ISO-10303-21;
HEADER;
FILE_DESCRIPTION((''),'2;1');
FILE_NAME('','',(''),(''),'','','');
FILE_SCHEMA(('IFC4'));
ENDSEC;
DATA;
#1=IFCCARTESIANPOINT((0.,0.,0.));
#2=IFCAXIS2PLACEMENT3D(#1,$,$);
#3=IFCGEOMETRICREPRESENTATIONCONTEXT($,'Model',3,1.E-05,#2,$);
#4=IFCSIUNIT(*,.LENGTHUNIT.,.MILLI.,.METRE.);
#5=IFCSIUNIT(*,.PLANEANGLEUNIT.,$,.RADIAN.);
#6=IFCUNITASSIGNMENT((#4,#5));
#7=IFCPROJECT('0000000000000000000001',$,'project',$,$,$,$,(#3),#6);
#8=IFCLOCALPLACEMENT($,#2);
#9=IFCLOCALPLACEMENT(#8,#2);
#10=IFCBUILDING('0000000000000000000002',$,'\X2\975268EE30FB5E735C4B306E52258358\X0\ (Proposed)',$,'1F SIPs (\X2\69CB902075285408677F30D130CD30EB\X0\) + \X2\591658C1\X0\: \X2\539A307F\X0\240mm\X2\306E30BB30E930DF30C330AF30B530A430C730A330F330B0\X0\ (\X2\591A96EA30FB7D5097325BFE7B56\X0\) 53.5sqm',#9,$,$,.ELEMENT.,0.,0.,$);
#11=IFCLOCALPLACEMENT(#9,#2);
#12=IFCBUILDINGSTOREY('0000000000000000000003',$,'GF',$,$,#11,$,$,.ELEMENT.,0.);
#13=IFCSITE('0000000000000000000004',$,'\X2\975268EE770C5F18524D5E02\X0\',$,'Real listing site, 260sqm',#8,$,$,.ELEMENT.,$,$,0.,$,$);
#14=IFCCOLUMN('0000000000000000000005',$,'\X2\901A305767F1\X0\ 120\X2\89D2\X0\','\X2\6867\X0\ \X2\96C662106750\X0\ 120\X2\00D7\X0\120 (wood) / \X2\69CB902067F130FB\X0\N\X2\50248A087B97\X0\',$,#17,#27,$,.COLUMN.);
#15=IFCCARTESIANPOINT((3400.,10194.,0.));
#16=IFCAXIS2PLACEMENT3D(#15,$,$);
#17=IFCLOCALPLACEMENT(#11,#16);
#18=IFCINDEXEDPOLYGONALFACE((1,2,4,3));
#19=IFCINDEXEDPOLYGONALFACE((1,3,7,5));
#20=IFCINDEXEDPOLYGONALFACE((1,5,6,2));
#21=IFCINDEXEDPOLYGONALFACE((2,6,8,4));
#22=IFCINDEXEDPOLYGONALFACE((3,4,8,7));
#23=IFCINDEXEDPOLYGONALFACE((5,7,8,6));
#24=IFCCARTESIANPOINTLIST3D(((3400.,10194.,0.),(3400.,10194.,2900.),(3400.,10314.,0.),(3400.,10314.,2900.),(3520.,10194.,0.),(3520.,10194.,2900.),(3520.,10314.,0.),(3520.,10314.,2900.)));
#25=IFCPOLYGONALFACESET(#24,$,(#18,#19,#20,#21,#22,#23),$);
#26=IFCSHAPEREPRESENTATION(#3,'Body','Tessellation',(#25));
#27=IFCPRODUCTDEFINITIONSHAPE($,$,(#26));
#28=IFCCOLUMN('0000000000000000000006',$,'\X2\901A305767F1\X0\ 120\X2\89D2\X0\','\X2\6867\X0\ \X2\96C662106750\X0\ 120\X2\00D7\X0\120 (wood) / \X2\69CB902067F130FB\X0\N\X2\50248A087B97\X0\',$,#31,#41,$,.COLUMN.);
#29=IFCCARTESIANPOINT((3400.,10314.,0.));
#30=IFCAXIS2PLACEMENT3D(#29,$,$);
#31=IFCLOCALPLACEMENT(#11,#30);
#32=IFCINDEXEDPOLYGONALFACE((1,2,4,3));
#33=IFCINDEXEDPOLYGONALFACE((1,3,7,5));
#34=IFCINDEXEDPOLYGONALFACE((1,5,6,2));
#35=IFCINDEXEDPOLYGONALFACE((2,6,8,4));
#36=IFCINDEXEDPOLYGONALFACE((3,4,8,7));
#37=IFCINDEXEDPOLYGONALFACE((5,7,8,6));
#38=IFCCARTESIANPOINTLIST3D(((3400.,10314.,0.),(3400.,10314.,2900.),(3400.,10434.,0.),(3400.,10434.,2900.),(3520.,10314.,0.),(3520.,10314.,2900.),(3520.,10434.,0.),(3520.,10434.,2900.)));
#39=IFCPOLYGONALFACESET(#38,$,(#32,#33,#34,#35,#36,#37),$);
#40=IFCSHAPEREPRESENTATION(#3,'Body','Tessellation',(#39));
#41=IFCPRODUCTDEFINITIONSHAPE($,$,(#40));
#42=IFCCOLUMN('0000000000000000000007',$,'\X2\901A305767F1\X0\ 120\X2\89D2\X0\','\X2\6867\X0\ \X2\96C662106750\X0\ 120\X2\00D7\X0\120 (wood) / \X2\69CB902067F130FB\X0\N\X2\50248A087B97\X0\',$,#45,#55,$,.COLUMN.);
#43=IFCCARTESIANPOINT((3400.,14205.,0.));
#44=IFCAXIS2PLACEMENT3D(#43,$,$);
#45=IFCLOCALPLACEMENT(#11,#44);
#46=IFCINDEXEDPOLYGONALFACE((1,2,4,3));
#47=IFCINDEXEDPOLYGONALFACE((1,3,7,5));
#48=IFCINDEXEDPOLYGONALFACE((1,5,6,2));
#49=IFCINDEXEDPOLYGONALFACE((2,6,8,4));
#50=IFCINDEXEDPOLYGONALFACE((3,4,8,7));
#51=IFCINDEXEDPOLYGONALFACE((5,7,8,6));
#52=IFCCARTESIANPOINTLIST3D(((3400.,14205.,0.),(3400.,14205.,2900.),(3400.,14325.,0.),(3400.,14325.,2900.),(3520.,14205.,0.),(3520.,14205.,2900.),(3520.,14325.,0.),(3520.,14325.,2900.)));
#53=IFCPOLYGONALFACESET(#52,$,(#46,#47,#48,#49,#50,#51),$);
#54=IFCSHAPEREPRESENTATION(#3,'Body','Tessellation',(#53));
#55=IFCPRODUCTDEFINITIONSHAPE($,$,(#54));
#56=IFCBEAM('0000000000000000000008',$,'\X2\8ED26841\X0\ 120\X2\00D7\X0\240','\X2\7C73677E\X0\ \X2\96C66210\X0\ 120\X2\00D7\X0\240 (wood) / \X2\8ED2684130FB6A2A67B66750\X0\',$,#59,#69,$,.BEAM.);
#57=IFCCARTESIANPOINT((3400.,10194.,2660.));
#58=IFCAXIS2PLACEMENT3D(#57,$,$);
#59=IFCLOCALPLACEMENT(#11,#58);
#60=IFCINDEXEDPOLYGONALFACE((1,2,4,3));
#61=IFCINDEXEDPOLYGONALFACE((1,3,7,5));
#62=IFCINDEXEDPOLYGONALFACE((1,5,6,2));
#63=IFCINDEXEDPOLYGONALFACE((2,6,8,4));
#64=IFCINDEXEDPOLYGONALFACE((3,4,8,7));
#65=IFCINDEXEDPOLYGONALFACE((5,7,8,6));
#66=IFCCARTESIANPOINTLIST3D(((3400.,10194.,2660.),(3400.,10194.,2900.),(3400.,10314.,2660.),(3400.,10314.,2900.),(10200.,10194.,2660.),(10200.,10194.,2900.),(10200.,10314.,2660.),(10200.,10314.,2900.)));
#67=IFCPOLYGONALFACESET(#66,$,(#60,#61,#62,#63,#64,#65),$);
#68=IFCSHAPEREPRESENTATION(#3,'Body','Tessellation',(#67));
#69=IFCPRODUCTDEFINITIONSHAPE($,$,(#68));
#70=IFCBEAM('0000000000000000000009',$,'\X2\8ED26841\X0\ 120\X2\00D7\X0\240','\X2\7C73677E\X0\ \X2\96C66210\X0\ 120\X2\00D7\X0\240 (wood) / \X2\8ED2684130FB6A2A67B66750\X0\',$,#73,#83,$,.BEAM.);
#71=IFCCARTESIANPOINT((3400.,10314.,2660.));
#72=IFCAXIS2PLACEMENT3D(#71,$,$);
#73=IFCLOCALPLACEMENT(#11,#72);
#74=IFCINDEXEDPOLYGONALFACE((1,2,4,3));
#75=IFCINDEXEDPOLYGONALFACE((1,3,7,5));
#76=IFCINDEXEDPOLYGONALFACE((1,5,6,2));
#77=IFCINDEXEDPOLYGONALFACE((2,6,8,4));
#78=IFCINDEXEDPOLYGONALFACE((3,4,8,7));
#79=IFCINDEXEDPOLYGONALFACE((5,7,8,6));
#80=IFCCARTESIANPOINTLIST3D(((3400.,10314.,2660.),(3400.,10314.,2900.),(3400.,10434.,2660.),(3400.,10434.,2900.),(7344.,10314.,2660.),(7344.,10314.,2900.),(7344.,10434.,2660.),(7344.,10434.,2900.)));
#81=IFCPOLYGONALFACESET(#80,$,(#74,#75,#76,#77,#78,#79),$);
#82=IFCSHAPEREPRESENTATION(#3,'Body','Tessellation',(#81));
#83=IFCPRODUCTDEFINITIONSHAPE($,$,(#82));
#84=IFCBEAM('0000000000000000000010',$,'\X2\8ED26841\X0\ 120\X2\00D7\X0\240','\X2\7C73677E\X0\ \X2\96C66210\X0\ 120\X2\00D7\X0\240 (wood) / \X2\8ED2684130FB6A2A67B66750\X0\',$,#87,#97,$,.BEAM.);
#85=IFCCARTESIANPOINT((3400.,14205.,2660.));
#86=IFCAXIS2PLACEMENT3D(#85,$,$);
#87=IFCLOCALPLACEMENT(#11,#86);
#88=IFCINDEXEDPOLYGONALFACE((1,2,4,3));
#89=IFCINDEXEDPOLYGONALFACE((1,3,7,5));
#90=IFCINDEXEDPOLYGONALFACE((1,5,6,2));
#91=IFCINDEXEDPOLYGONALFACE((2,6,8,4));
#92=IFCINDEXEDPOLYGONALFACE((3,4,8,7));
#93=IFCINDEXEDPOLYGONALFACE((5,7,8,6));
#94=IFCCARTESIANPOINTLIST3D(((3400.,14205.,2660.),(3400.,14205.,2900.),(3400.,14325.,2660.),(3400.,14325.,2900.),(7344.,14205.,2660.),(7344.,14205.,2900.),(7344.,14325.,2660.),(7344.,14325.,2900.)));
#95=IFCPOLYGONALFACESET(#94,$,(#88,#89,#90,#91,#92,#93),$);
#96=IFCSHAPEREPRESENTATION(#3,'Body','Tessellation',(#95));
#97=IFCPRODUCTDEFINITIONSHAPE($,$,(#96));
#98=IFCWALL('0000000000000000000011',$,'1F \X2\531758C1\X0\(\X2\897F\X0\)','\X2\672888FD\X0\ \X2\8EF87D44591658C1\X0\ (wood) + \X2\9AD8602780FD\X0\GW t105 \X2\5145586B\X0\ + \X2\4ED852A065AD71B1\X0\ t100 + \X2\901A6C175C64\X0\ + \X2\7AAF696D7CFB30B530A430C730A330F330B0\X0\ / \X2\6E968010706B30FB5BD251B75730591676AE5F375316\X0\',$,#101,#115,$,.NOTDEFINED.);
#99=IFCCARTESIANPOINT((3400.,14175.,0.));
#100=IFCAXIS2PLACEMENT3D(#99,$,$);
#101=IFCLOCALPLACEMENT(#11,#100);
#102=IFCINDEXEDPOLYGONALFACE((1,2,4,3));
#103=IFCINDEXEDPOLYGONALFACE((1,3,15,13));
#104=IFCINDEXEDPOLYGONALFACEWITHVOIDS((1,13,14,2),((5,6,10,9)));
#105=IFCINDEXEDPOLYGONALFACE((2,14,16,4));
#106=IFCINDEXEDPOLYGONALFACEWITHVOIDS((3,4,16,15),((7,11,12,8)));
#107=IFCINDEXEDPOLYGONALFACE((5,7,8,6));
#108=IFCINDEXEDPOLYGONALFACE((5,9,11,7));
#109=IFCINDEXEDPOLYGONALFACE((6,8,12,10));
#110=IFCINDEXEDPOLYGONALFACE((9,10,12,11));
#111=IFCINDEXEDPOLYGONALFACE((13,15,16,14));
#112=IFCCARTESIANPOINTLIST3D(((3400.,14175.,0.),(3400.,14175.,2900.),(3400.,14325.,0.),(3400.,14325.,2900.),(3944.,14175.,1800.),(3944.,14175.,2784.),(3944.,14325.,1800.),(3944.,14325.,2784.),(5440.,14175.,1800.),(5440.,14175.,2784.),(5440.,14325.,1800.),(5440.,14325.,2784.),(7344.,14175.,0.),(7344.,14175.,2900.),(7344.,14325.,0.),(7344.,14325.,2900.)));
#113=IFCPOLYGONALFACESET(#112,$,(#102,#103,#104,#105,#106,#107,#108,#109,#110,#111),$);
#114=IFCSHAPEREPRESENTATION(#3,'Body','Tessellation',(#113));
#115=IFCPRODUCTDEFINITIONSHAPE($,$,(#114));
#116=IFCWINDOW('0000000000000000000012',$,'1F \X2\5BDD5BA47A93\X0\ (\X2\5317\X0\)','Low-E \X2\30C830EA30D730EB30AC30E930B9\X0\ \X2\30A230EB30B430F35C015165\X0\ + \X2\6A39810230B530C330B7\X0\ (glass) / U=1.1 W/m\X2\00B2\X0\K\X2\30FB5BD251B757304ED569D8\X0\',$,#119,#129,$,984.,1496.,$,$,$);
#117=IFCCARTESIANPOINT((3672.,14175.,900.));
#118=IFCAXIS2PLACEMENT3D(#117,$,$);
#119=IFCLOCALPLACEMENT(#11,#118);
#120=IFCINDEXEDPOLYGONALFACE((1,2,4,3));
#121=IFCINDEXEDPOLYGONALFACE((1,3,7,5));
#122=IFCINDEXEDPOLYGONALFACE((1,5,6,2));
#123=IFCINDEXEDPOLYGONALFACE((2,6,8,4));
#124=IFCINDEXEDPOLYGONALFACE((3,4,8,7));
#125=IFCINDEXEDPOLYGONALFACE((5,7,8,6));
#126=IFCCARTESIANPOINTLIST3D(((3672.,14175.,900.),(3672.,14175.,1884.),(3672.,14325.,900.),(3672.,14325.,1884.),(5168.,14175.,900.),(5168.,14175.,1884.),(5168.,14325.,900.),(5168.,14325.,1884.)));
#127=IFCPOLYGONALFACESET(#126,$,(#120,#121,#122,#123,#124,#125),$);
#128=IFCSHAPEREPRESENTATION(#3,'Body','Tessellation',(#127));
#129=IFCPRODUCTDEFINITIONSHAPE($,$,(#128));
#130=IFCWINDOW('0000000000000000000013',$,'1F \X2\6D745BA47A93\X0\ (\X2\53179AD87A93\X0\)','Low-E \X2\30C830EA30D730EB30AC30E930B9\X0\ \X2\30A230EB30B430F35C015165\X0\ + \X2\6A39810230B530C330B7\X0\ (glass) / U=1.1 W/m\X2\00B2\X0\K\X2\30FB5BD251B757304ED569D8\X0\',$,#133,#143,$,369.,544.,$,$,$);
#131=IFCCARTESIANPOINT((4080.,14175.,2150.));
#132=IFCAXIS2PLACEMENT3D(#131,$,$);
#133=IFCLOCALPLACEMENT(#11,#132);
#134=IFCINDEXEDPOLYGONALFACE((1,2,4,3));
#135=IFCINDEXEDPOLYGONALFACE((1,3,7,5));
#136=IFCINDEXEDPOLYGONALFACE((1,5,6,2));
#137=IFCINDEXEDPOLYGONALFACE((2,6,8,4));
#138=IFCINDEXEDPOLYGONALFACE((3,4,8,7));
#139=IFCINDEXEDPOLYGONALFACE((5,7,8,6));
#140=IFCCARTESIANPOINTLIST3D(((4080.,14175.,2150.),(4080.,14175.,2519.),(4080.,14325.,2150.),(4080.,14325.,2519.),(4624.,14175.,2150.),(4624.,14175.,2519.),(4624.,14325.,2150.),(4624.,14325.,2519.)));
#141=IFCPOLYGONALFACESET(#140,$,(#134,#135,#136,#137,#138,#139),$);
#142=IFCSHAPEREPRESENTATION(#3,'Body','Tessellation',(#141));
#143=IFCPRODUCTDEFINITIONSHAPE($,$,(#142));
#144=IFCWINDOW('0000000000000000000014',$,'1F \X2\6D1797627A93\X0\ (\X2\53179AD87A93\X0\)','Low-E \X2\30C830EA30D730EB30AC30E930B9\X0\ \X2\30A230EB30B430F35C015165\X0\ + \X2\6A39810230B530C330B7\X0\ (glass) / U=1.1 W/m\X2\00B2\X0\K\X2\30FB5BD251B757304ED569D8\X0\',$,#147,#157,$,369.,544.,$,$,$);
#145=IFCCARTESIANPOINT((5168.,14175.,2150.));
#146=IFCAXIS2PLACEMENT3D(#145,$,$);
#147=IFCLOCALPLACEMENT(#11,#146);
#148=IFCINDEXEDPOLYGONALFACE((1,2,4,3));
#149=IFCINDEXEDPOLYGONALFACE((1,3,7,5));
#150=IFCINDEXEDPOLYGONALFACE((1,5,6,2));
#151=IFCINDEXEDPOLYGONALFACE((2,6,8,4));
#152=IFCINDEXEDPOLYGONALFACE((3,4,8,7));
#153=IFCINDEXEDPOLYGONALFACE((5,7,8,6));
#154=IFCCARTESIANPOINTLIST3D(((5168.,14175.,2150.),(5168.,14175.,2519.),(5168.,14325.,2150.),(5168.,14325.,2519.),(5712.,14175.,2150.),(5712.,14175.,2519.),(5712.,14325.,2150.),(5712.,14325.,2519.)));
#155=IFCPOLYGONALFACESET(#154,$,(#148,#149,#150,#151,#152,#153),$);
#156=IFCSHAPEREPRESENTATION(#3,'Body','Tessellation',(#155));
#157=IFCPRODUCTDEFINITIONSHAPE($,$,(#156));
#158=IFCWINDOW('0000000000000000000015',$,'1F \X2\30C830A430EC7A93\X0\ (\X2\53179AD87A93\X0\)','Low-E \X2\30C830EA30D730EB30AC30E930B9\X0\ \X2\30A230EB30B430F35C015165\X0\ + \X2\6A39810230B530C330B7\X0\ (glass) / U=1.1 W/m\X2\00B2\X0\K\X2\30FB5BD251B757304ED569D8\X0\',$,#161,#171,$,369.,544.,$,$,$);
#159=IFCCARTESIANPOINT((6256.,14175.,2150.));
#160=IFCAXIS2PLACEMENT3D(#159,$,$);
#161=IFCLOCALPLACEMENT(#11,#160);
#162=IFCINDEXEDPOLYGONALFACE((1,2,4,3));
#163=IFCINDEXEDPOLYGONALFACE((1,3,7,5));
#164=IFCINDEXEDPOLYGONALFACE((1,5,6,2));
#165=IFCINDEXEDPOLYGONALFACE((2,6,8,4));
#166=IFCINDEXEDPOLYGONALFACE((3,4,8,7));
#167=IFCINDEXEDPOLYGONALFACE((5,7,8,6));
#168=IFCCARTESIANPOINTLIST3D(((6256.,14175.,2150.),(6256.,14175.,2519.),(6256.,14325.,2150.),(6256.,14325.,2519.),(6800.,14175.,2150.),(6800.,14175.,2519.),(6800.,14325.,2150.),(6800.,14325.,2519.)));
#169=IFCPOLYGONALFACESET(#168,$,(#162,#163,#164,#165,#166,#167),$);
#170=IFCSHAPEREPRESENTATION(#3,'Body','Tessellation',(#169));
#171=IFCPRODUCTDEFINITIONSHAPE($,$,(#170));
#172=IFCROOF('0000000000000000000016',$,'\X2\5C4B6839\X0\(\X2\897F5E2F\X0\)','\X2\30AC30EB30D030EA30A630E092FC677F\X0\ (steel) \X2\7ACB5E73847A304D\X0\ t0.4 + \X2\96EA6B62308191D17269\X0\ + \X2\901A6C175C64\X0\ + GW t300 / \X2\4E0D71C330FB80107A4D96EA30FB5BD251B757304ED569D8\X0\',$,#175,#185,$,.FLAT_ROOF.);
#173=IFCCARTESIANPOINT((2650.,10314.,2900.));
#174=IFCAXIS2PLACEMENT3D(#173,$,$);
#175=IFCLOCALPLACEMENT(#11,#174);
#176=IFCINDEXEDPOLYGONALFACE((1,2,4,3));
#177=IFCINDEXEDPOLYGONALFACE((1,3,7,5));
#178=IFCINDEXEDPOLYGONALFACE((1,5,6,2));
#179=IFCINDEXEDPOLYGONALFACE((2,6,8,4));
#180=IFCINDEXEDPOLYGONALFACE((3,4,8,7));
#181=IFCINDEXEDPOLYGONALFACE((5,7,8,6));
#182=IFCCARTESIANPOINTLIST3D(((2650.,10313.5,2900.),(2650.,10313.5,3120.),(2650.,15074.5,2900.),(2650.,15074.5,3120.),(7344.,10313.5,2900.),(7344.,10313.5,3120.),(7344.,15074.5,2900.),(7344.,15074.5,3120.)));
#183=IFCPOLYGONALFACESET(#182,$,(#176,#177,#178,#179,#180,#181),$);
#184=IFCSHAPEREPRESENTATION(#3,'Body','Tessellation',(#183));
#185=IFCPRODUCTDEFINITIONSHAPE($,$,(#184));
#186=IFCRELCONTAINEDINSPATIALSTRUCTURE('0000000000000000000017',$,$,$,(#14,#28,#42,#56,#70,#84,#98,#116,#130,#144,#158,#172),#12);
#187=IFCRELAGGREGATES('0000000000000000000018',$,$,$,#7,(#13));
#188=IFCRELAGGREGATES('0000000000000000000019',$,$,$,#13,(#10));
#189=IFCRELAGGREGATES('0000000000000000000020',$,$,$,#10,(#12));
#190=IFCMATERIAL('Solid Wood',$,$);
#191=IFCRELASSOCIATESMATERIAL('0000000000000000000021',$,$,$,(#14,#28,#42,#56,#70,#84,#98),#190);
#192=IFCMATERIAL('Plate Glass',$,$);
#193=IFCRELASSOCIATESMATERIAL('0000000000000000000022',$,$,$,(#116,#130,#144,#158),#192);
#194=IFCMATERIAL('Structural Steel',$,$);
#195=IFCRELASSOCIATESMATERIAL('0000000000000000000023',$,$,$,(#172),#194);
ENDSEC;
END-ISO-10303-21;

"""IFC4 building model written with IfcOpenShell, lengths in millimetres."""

from ifc_helpers import new_model, si_unit, frame, frame_2d, origin, place, context, project, spatial, rectangle, extrude, material, element, fill, save


model = new_model("IFC4")

# Units and contexts
model_context = context("Model", 3, precision=1e-05, world=origin())
ifc_project = project(units=[si_unit("LENGTHUNIT", "METRE", prefix="MILLI"), si_unit("PLANEANGLEUNIT", "RADIAN")], contexts=[model_context])

# Site, building, storey
site_placement = place(None, origin())
site = spatial("IfcSite", under=ifc_project, at=site_placement, Name="青森県弘前市", ObjectType="Real listing site, 260sqm", CompositionType="ELEMENT", RefElevation=0.0)
building_placement = place(site_placement, origin())
building = spatial("IfcBuilding", under=site, at=building_placement, Name="青森・平屋の別荘 (Proposed)", ObjectType="1F SIPs (構造用合板パネル) + 外壁: 厚み240mmのセラミックサイディング (多雪・結露対策) 53.5sqm", CompositionType="ELEMENT", ElevationOfRefHeight=0.0, ElevationOfTerrain=0.0)
storey_placement = place(building_placement, origin())
storey = spatial("IfcBuildingStorey", under=building, at=storey_placement, Name="GF", CompositionType="ELEMENT", Elevation=0.0)

# Columns
ifc_material_1 = material(Name="Solid Wood")
column_1_placement = place(storey_placement, frame((3400.0, 10194.0, 0.0)))
element("IfcColumn", 1, at=column_1_placement, inside=storey, material=ifc_material_1, Name="通し柱 120角", Description="桧 集成材 120×120 (wood) / 構造柱・N値計算", PredefinedType="COLUMN", context=model_context, shape_type="SweptSolid", body=[
    extrude(rectangle(XDim=120.0, YDim=120.0, at=frame_2d((60.0, 60.0))), frame((3400.0, 10194.0, 0.0)), (0.0, 0.0, 1.0), 2900.0),
])
column_2_placement = place(storey_placement, frame((3400.0, 10314.0, 0.0)))
element("IfcColumn", 2, at=column_2_placement, inside=storey, material=ifc_material_1, Name="通し柱 120角", Description="桧 集成材 120×120 (wood) / 構造柱・N値計算", PredefinedType="COLUMN", context=model_context, shape_type="SweptSolid", body=[
    extrude(rectangle(XDim=120.0, YDim=120.0, at=frame_2d((60.0, 60.0))), frame((3400.0, 10314.0, 0.0)), (0.0, 0.0, 1.0), 2900.0),
])
column_3_placement = place(storey_placement, frame((3400.0, 14205.0, 0.0)))
element("IfcColumn", 3, at=column_3_placement, inside=storey, material=ifc_material_1, Name="通し柱 120角", Description="桧 集成材 120×120 (wood) / 構造柱・N値計算", PredefinedType="COLUMN", context=model_context, shape_type="SweptSolid", body=[
    extrude(rectangle(XDim=120.0, YDim=120.0, at=frame_2d((60.0, 60.0))), frame((3400.0, 14205.0, 0.0)), (0.0, 0.0, 1.0), 2900.0),
])

# Beams
beam_1_placement = place(storey_placement, frame((3400.0, 10194.0, 2660.0)))
element("IfcBeam", 4, at=beam_1_placement, inside=storey, material=ifc_material_1, Name="軒桁 120×240", Description="米松 集成 120×240 (wood) / 軒桁・横架材", PredefinedType="BEAM", context=model_context, shape_type="SweptSolid", body=[
    extrude(rectangle(XDim=6800.0, YDim=120.0, at=frame_2d((3400.0, 60.0))), frame((3400.0, 10194.0, 2660.0)), (0.0, 0.0, 1.0), 240.0),
])
beam_2_placement = place(storey_placement, frame((3400.0, 10314.0, 2660.0)))
element("IfcBeam", 5, at=beam_2_placement, inside=storey, material=ifc_material_1, Name="軒桁 120×240", Description="米松 集成 120×240 (wood) / 軒桁・横架材", PredefinedType="BEAM", context=model_context, shape_type="SweptSolid", body=[
    extrude(rectangle(XDim=3944.0, YDim=120.0, at=frame_2d((1972.0, 60.0))), frame((3400.0, 10314.0, 2660.0)), (0.0, 0.0, 1.0), 240.0),
])
beam_3_placement = place(storey_placement, frame((3400.0, 14205.0, 2660.0)))
element("IfcBeam", 6, at=beam_3_placement, inside=storey, material=ifc_material_1, Name="軒桁 120×240", Description="米松 集成 120×240 (wood) / 軒桁・横架材", PredefinedType="BEAM", context=model_context, shape_type="SweptSolid", body=[
    extrude(rectangle(XDim=3944.0, YDim=120.0, at=frame_2d((1972.0, 60.0))), frame((3400.0, 14205.0, 2660.0)), (0.0, 0.0, 1.0), 240.0),
])

# Wall, openings, windows
wall_1_placement = place(storey_placement, frame((3400.0, 14175.0, 0.0)))
wall_1 = element("IfcWall", 7, at=wall_1_placement, inside=storey, material=ifc_material_1, Name="1F 北壁(西)", Description="木製 軸組外壁 (wood) + 高性能GW t105 充填 + 付加断熱 t100 + 通気層 + 窯業系サイディング / 準耐火・寒冷地外皮強化", PredefinedType="NOTDEFINED", context=model_context, shape_type="SweptSolid", body=[
    extrude(rectangle(XDim=3944.0, YDim=150.0, at=frame_2d((1972.0, 75.0))), frame((3400.0, 14175.0, 0.0)), (0.0, 0.0, 1.0), 2900.0),
])
opening_1_placement = place(storey_placement, frame((3672.0, 14175.0, 900.0)))
opening_1 = element("IfcOpeningElement", 8, at=opening_1_placement, cuts=wall_1, PredefinedType="NOTDEFINED", context=model_context, shape_type="SweptSolid", body=[
    extrude(rectangle(XDim=1496.0, YDim=150.0, at=frame_2d((748.0, 75.0))), frame((3672.0, 14175.0, 900.0)), (0.0, 0.0, 1.0), 984.0),
])
opening_2_placement = place(storey_placement, frame((4080.0, 14175.0, 2150.0)))
opening_2 = element("IfcOpeningElement", 9, at=opening_2_placement, cuts=wall_1, PredefinedType="NOTDEFINED", context=model_context, shape_type="SweptSolid", body=[
    extrude(rectangle(XDim=544.0, YDim=150.0, at=frame_2d((272.0, 75.0))), frame((4080.0, 14175.0, 2150.0)), (0.0, 0.0, 1.0), 369.0),
])
opening_3_placement = place(storey_placement, frame((5168.0, 14175.0, 2150.0)))
opening_3 = element("IfcOpeningElement", 10, at=opening_3_placement, cuts=wall_1, PredefinedType="NOTDEFINED", context=model_context, shape_type="SweptSolid", body=[
    extrude(rectangle(XDim=544.0, YDim=150.0, at=frame_2d((272.0, 75.0))), frame((5168.0, 14175.0, 2150.0)), (0.0, 0.0, 1.0), 369.0),
])
opening_4_placement = place(storey_placement, frame((6256.0, 14175.0, 2150.0)))
opening_4 = element("IfcOpeningElement", 11, at=opening_4_placement, cuts=wall_1, PredefinedType="NOTDEFINED", context=model_context, shape_type="SweptSolid", body=[
    extrude(rectangle(XDim=544.0, YDim=150.0, at=frame_2d((272.0, 75.0))), frame((6256.0, 14175.0, 2150.0)), (0.0, 0.0, 1.0), 369.0),
])
ifc_material_2 = material(Name="Plate Glass")
window_1_placement = place(storey_placement, frame((3672.0, 14175.0, 900.0)))
window_1 = element("IfcWindow", 12, at=window_1_placement, inside=storey, material=ifc_material_2, Name="1F 寝室窓 (北)", Description="Low-E トリプルガラス アルゴン封入 + 樹脂サッシ (glass) / U=1.1 W/m²K・寒冷地仕様", OverallHeight=984.0, OverallWidth=1496.0, context=model_context, shape_type="SweptSolid", body=[
    extrude(rectangle(XDim=1496.0, YDim=150.0, at=frame_2d((748.0, 75.0))), frame((3672.0, 14175.0, 900.0)), (0.0, 0.0, 1.0), 984.0),
])
fill(opening_1, window_1)
window_2_placement = place(storey_placement, frame((4080.0, 14175.0, 2150.0)))
window_2 = element("IfcWindow", 13, at=window_2_placement, inside=storey, material=ifc_material_2, Name="1F 浴室窓 (北高窓)", Description="Low-E トリプルガラス アルゴン封入 + 樹脂サッシ (glass) / U=1.1 W/m²K・寒冷地仕様", OverallHeight=369.0, OverallWidth=544.0, context=model_context, shape_type="SweptSolid", body=[
    extrude(rectangle(XDim=544.0, YDim=150.0, at=frame_2d((272.0, 75.0))), frame((4080.0, 14175.0, 2150.0)), (0.0, 0.0, 1.0), 369.0),
])
fill(opening_2, window_2)
window_3_placement = place(storey_placement, frame((5168.0, 14175.0, 2150.0)))
window_3 = element("IfcWindow", 14, at=window_3_placement, inside=storey, material=ifc_material_2, Name="1F 洗面窓 (北高窓)", Description="Low-E トリプルガラス アルゴン封入 + 樹脂サッシ (glass) / U=1.1 W/m²K・寒冷地仕様", OverallHeight=369.0, OverallWidth=544.0, context=model_context, shape_type="SweptSolid", body=[
    extrude(rectangle(XDim=544.0, YDim=150.0, at=frame_2d((272.0, 75.0))), frame((5168.0, 14175.0, 2150.0)), (0.0, 0.0, 1.0), 369.0),
])
fill(opening_3, window_3)
window_4_placement = place(storey_placement, frame((6256.0, 14175.0, 2150.0)))
window_4 = element("IfcWindow", 15, at=window_4_placement, inside=storey, material=ifc_material_2, Name="1F トイレ窓 (北高窓)", Description="Low-E トリプルガラス アルゴン封入 + 樹脂サッシ (glass) / U=1.1 W/m²K・寒冷地仕様", OverallHeight=369.0, OverallWidth=544.0, context=model_context, shape_type="SweptSolid", body=[
    extrude(rectangle(XDim=544.0, YDim=150.0, at=frame_2d((272.0, 75.0))), frame((6256.0, 14175.0, 2150.0)), (0.0, 0.0, 1.0), 369.0),
])
fill(opening_4, window_4)

# Roof
ifc_material_3 = material(Name="Structural Steel")
roof_placement = place(storey_placement, frame((2650.0, 10314.0, 2900.0)))
element("IfcRoof", 16, at=roof_placement, inside=storey, material=ifc_material_3, Name="屋根(西帯)", Description="ガルバリウム鋼板 (steel) 立平葺き t0.4 + 雪止め金物 + 通気層 + GW t300 / 不燃・耐積雪・寒冷地仕様", PredefinedType="FLAT_ROOF", context=model_context, shape_type="SweptSolid", body=[
    extrude(rectangle(XDim=4694.0, YDim=4761.0, at=frame_2d((2347.0, 2380.0))), frame((2650.0, 10314.0, 2900.0)), (0.0, 0.0, 1.0), 220.0),
])

save(model, "model.ifc")
